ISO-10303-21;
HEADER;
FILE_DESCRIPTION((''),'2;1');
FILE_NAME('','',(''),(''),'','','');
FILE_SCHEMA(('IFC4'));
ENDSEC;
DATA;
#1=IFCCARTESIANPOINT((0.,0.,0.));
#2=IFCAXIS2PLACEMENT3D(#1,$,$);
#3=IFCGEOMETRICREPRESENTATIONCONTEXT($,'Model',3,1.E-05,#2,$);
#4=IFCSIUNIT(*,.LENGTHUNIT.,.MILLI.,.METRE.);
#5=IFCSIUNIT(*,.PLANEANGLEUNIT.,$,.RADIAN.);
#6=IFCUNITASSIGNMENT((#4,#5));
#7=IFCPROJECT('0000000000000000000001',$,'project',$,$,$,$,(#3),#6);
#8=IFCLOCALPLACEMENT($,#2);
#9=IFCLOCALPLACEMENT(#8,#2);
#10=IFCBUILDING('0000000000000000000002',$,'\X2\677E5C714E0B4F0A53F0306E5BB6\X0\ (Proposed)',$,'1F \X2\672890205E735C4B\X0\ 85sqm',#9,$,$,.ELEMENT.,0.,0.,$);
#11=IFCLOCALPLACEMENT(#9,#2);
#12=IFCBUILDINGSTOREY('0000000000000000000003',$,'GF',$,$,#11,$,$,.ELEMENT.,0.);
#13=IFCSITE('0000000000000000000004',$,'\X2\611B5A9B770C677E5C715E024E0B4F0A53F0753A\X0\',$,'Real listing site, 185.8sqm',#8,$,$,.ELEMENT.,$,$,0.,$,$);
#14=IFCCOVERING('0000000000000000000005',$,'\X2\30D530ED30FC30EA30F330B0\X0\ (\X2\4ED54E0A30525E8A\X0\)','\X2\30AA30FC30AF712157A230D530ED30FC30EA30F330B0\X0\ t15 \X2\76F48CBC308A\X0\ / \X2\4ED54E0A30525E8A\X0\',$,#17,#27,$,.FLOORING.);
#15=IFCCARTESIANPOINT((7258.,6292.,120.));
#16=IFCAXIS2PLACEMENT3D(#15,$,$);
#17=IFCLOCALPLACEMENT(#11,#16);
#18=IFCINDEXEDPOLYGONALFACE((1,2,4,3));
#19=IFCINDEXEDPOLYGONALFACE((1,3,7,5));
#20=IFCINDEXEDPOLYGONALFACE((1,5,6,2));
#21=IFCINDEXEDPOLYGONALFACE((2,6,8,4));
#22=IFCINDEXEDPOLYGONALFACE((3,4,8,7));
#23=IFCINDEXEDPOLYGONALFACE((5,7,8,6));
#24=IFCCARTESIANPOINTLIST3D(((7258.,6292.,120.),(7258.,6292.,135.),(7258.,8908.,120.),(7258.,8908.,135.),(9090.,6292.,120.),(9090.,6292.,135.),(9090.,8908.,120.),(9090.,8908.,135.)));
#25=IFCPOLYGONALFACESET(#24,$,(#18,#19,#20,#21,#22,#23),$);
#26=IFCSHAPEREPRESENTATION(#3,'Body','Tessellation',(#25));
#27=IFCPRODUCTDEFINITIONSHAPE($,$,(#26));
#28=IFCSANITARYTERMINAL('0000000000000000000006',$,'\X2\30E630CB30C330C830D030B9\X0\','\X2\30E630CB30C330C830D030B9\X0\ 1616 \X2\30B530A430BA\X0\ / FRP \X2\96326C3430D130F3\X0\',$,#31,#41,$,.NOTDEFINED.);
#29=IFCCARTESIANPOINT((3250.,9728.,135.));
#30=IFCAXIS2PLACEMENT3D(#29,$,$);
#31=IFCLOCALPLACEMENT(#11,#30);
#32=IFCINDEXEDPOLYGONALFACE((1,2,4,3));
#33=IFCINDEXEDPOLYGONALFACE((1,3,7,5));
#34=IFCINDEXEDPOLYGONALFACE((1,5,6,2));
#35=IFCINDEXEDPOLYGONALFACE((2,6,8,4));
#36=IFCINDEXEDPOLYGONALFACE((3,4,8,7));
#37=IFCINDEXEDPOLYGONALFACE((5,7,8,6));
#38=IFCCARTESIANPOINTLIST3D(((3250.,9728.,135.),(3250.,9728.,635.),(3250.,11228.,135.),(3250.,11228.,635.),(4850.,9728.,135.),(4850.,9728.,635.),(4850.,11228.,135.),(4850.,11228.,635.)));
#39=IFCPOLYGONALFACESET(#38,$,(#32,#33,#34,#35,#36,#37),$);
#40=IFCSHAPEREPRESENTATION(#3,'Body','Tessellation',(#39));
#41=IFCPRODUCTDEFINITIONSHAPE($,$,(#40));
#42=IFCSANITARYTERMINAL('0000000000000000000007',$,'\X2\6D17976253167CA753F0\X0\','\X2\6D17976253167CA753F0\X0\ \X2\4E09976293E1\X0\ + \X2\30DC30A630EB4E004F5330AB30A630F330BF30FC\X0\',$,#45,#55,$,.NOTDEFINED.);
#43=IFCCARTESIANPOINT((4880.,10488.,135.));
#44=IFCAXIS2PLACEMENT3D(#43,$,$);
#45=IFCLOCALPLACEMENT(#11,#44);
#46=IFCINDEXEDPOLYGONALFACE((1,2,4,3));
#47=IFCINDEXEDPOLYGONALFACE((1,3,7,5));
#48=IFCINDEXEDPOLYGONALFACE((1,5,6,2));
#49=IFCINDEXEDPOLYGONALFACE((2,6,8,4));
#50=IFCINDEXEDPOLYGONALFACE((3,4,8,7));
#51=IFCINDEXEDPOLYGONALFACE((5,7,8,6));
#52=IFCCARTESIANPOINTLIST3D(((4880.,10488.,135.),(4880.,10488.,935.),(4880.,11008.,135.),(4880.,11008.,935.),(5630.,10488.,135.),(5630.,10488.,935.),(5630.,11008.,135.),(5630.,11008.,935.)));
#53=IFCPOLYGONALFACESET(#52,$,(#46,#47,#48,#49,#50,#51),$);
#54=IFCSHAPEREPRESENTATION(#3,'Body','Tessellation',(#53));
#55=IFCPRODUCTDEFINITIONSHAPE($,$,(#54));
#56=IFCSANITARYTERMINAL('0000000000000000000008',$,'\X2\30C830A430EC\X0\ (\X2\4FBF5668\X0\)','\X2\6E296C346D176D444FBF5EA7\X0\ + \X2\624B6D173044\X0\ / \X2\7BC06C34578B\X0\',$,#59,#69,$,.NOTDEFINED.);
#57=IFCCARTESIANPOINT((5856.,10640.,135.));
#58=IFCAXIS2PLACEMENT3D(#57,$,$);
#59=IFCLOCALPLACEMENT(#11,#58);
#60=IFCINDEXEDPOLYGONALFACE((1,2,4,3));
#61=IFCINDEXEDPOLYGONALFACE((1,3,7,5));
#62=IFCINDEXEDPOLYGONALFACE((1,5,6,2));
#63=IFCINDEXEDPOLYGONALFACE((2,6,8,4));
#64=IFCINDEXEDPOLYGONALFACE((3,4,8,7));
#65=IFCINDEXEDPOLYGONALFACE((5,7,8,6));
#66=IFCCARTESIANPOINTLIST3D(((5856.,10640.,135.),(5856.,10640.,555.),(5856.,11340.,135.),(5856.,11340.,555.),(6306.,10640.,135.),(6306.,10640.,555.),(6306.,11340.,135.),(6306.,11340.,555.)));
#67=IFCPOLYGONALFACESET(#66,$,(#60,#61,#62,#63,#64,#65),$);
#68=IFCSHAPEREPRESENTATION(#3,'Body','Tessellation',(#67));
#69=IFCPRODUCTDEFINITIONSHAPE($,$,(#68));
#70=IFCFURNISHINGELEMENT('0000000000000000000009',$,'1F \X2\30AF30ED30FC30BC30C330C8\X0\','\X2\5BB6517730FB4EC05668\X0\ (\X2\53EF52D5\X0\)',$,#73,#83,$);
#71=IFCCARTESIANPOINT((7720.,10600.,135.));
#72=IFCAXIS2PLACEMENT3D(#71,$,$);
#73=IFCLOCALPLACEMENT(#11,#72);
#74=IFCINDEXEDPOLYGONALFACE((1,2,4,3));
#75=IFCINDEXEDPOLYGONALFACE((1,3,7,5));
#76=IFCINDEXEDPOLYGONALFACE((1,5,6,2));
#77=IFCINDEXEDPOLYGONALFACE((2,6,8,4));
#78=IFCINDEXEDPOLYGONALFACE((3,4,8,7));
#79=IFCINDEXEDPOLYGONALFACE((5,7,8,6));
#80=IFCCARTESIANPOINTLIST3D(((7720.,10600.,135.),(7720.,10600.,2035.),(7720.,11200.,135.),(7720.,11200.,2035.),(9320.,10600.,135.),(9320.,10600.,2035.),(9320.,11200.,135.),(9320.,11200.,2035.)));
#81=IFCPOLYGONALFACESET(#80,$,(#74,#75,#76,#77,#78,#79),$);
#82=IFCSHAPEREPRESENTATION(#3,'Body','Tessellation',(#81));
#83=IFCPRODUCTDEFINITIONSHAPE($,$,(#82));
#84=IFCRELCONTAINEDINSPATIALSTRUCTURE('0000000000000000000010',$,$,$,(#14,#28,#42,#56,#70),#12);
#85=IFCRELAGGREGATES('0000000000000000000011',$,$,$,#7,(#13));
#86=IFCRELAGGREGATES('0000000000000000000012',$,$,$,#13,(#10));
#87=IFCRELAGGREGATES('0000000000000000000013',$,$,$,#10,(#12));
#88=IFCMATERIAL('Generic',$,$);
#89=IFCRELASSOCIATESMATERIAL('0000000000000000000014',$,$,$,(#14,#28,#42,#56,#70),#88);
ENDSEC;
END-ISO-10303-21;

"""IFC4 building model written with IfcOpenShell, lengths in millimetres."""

from ifc_helpers import new_model, si_unit, frame, frame_2d, origin, place, context, project, spatial, rectangle, extrude, material, element, save


model = new_model("IFC4")

# Units and contexts
model_context = context("Model", 3, precision=1e-05, world=origin())
ifc_project = project(units=[si_unit("LENGTHUNIT", "METRE", prefix="MILLI"), si_unit("PLANEANGLEUNIT", "RADIAN")], contexts=[model_context])

# Site, building, storey
site_placement = place(None, origin())
site = spatial("IfcSite", under=ifc_project, at=site_placement, Name="愛媛県松山市下伊台町", ObjectType="Real listing site, 185.8sqm", CompositionType="ELEMENT", RefElevation=0.0)
building_placement = place(site_placement, origin())
building = spatial("IfcBuilding", under=site, at=building_placement, Name="松山下伊台の家 (Proposed)", ObjectType="1F 木造平屋 85sqm", CompositionType="ELEMENT", ElevationOfRefHeight=0.0, ElevationOfTerrain=0.0)
storey_placement = place(building_placement, origin())
storey = spatial("IfcBuildingStorey", under=building, at=storey_placement, Name="GF", CompositionType="ELEMENT", Elevation=0.0)

# Covering
ifc_material_1 = material(Name="Generic")
covering_1_placement = place(storey_placement, frame((7258.0, 6292.0, 120.0)))
element("IfcCovering", 1, at=covering_1_placement, inside=storey, material=ifc_material_1, Name="フローリング (仕上げ床)", Description="オーク無垢フローリング t15 直貼り / 仕上げ床", PredefinedType="FLOORING", context=model_context, shape_type="SweptSolid", body=[
    extrude(rectangle(XDim=1832.0, YDim=2616.0, at=frame_2d((916.0, 1308.0))), frame((7258.0, 6292.0, 120.0)), (0.0, 0.0, 1.0), 15.0),
])

# Sanitary terminals
sanitary_terminal_1_placement = place(storey_placement, frame((3250.0, 9728.0, 135.0)))
element("IfcSanitaryTerminal", 2, at=sanitary_terminal_1_placement, inside=storey, material=ifc_material_1, Name="ユニットバス", Description="ユニットバス 1616 サイズ / FRP 防水パン", PredefinedType="NOTDEFINED", context=model_context, shape_type="SweptSolid", body=[
    extrude(rectangle(XDim=1600.0, YDim=1500.0, at=frame_2d((800.0, 750.0))), frame((3250.0, 9728.0, 135.0)), (0.0, 0.0, 1.0), 500.0),
])
sanitary_terminal_2_placement = place(storey_placement, frame((4880.0, 10488.0, 135.0)))
element("IfcSanitaryTerminal", 3, at=sanitary_terminal_2_placement, inside=storey, material=ifc_material_1, Name="洗面化粧台", Description="洗面化粧台 三面鏡 + ボウル一体カウンター", PredefinedType="NOTDEFINED", context=model_context, shape_type="SweptSolid", body=[
    extrude(rectangle(XDim=750.0, YDim=520.0, at=frame_2d((375.0, 260.0))), frame((4880.0, 10488.0, 135.0)), (0.0, 0.0, 1.0), 800.0),
])
sanitary_terminal_3_placement = place(storey_placement, frame((5856.0, 10640.0, 135.0)))
element("IfcSanitaryTerminal", 4, at=sanitary_terminal_3_placement, inside=storey, material=ifc_material_1, Name="トイレ (便器)", Description="温水洗浄便座 + 手洗い / 節水型", PredefinedType="NOTDEFINED", context=model_context, shape_type="SweptSolid", body=[
    extrude(rectangle(XDim=450.0, YDim=700.0, at=frame_2d((225.0, 350.0))), frame((5856.0, 10640.0, 135.0)), (0.0, 0.0, 1.0), 420.0),
])

# Furnishing element
furnishing_placement = place(storey_placement, frame((7720.0, 10600.0, 135.0)))
element("IfcFurnishingElement", 5, at=furnishing_placement, inside=storey, material=ifc_material_1, Name="1F クローゼット", Description="家具・什器 (可動)", context=model_context, shape_type="SweptSolid", body=[
    extrude(rectangle(XDim=1600.0, YDim=600.0, at=frame_2d((800.0, 300.0))), frame((7720.0, 10600.0, 135.0)), (0.0, 0.0, 1.0), 1900.0),
])

save(model, "model.ifc")
